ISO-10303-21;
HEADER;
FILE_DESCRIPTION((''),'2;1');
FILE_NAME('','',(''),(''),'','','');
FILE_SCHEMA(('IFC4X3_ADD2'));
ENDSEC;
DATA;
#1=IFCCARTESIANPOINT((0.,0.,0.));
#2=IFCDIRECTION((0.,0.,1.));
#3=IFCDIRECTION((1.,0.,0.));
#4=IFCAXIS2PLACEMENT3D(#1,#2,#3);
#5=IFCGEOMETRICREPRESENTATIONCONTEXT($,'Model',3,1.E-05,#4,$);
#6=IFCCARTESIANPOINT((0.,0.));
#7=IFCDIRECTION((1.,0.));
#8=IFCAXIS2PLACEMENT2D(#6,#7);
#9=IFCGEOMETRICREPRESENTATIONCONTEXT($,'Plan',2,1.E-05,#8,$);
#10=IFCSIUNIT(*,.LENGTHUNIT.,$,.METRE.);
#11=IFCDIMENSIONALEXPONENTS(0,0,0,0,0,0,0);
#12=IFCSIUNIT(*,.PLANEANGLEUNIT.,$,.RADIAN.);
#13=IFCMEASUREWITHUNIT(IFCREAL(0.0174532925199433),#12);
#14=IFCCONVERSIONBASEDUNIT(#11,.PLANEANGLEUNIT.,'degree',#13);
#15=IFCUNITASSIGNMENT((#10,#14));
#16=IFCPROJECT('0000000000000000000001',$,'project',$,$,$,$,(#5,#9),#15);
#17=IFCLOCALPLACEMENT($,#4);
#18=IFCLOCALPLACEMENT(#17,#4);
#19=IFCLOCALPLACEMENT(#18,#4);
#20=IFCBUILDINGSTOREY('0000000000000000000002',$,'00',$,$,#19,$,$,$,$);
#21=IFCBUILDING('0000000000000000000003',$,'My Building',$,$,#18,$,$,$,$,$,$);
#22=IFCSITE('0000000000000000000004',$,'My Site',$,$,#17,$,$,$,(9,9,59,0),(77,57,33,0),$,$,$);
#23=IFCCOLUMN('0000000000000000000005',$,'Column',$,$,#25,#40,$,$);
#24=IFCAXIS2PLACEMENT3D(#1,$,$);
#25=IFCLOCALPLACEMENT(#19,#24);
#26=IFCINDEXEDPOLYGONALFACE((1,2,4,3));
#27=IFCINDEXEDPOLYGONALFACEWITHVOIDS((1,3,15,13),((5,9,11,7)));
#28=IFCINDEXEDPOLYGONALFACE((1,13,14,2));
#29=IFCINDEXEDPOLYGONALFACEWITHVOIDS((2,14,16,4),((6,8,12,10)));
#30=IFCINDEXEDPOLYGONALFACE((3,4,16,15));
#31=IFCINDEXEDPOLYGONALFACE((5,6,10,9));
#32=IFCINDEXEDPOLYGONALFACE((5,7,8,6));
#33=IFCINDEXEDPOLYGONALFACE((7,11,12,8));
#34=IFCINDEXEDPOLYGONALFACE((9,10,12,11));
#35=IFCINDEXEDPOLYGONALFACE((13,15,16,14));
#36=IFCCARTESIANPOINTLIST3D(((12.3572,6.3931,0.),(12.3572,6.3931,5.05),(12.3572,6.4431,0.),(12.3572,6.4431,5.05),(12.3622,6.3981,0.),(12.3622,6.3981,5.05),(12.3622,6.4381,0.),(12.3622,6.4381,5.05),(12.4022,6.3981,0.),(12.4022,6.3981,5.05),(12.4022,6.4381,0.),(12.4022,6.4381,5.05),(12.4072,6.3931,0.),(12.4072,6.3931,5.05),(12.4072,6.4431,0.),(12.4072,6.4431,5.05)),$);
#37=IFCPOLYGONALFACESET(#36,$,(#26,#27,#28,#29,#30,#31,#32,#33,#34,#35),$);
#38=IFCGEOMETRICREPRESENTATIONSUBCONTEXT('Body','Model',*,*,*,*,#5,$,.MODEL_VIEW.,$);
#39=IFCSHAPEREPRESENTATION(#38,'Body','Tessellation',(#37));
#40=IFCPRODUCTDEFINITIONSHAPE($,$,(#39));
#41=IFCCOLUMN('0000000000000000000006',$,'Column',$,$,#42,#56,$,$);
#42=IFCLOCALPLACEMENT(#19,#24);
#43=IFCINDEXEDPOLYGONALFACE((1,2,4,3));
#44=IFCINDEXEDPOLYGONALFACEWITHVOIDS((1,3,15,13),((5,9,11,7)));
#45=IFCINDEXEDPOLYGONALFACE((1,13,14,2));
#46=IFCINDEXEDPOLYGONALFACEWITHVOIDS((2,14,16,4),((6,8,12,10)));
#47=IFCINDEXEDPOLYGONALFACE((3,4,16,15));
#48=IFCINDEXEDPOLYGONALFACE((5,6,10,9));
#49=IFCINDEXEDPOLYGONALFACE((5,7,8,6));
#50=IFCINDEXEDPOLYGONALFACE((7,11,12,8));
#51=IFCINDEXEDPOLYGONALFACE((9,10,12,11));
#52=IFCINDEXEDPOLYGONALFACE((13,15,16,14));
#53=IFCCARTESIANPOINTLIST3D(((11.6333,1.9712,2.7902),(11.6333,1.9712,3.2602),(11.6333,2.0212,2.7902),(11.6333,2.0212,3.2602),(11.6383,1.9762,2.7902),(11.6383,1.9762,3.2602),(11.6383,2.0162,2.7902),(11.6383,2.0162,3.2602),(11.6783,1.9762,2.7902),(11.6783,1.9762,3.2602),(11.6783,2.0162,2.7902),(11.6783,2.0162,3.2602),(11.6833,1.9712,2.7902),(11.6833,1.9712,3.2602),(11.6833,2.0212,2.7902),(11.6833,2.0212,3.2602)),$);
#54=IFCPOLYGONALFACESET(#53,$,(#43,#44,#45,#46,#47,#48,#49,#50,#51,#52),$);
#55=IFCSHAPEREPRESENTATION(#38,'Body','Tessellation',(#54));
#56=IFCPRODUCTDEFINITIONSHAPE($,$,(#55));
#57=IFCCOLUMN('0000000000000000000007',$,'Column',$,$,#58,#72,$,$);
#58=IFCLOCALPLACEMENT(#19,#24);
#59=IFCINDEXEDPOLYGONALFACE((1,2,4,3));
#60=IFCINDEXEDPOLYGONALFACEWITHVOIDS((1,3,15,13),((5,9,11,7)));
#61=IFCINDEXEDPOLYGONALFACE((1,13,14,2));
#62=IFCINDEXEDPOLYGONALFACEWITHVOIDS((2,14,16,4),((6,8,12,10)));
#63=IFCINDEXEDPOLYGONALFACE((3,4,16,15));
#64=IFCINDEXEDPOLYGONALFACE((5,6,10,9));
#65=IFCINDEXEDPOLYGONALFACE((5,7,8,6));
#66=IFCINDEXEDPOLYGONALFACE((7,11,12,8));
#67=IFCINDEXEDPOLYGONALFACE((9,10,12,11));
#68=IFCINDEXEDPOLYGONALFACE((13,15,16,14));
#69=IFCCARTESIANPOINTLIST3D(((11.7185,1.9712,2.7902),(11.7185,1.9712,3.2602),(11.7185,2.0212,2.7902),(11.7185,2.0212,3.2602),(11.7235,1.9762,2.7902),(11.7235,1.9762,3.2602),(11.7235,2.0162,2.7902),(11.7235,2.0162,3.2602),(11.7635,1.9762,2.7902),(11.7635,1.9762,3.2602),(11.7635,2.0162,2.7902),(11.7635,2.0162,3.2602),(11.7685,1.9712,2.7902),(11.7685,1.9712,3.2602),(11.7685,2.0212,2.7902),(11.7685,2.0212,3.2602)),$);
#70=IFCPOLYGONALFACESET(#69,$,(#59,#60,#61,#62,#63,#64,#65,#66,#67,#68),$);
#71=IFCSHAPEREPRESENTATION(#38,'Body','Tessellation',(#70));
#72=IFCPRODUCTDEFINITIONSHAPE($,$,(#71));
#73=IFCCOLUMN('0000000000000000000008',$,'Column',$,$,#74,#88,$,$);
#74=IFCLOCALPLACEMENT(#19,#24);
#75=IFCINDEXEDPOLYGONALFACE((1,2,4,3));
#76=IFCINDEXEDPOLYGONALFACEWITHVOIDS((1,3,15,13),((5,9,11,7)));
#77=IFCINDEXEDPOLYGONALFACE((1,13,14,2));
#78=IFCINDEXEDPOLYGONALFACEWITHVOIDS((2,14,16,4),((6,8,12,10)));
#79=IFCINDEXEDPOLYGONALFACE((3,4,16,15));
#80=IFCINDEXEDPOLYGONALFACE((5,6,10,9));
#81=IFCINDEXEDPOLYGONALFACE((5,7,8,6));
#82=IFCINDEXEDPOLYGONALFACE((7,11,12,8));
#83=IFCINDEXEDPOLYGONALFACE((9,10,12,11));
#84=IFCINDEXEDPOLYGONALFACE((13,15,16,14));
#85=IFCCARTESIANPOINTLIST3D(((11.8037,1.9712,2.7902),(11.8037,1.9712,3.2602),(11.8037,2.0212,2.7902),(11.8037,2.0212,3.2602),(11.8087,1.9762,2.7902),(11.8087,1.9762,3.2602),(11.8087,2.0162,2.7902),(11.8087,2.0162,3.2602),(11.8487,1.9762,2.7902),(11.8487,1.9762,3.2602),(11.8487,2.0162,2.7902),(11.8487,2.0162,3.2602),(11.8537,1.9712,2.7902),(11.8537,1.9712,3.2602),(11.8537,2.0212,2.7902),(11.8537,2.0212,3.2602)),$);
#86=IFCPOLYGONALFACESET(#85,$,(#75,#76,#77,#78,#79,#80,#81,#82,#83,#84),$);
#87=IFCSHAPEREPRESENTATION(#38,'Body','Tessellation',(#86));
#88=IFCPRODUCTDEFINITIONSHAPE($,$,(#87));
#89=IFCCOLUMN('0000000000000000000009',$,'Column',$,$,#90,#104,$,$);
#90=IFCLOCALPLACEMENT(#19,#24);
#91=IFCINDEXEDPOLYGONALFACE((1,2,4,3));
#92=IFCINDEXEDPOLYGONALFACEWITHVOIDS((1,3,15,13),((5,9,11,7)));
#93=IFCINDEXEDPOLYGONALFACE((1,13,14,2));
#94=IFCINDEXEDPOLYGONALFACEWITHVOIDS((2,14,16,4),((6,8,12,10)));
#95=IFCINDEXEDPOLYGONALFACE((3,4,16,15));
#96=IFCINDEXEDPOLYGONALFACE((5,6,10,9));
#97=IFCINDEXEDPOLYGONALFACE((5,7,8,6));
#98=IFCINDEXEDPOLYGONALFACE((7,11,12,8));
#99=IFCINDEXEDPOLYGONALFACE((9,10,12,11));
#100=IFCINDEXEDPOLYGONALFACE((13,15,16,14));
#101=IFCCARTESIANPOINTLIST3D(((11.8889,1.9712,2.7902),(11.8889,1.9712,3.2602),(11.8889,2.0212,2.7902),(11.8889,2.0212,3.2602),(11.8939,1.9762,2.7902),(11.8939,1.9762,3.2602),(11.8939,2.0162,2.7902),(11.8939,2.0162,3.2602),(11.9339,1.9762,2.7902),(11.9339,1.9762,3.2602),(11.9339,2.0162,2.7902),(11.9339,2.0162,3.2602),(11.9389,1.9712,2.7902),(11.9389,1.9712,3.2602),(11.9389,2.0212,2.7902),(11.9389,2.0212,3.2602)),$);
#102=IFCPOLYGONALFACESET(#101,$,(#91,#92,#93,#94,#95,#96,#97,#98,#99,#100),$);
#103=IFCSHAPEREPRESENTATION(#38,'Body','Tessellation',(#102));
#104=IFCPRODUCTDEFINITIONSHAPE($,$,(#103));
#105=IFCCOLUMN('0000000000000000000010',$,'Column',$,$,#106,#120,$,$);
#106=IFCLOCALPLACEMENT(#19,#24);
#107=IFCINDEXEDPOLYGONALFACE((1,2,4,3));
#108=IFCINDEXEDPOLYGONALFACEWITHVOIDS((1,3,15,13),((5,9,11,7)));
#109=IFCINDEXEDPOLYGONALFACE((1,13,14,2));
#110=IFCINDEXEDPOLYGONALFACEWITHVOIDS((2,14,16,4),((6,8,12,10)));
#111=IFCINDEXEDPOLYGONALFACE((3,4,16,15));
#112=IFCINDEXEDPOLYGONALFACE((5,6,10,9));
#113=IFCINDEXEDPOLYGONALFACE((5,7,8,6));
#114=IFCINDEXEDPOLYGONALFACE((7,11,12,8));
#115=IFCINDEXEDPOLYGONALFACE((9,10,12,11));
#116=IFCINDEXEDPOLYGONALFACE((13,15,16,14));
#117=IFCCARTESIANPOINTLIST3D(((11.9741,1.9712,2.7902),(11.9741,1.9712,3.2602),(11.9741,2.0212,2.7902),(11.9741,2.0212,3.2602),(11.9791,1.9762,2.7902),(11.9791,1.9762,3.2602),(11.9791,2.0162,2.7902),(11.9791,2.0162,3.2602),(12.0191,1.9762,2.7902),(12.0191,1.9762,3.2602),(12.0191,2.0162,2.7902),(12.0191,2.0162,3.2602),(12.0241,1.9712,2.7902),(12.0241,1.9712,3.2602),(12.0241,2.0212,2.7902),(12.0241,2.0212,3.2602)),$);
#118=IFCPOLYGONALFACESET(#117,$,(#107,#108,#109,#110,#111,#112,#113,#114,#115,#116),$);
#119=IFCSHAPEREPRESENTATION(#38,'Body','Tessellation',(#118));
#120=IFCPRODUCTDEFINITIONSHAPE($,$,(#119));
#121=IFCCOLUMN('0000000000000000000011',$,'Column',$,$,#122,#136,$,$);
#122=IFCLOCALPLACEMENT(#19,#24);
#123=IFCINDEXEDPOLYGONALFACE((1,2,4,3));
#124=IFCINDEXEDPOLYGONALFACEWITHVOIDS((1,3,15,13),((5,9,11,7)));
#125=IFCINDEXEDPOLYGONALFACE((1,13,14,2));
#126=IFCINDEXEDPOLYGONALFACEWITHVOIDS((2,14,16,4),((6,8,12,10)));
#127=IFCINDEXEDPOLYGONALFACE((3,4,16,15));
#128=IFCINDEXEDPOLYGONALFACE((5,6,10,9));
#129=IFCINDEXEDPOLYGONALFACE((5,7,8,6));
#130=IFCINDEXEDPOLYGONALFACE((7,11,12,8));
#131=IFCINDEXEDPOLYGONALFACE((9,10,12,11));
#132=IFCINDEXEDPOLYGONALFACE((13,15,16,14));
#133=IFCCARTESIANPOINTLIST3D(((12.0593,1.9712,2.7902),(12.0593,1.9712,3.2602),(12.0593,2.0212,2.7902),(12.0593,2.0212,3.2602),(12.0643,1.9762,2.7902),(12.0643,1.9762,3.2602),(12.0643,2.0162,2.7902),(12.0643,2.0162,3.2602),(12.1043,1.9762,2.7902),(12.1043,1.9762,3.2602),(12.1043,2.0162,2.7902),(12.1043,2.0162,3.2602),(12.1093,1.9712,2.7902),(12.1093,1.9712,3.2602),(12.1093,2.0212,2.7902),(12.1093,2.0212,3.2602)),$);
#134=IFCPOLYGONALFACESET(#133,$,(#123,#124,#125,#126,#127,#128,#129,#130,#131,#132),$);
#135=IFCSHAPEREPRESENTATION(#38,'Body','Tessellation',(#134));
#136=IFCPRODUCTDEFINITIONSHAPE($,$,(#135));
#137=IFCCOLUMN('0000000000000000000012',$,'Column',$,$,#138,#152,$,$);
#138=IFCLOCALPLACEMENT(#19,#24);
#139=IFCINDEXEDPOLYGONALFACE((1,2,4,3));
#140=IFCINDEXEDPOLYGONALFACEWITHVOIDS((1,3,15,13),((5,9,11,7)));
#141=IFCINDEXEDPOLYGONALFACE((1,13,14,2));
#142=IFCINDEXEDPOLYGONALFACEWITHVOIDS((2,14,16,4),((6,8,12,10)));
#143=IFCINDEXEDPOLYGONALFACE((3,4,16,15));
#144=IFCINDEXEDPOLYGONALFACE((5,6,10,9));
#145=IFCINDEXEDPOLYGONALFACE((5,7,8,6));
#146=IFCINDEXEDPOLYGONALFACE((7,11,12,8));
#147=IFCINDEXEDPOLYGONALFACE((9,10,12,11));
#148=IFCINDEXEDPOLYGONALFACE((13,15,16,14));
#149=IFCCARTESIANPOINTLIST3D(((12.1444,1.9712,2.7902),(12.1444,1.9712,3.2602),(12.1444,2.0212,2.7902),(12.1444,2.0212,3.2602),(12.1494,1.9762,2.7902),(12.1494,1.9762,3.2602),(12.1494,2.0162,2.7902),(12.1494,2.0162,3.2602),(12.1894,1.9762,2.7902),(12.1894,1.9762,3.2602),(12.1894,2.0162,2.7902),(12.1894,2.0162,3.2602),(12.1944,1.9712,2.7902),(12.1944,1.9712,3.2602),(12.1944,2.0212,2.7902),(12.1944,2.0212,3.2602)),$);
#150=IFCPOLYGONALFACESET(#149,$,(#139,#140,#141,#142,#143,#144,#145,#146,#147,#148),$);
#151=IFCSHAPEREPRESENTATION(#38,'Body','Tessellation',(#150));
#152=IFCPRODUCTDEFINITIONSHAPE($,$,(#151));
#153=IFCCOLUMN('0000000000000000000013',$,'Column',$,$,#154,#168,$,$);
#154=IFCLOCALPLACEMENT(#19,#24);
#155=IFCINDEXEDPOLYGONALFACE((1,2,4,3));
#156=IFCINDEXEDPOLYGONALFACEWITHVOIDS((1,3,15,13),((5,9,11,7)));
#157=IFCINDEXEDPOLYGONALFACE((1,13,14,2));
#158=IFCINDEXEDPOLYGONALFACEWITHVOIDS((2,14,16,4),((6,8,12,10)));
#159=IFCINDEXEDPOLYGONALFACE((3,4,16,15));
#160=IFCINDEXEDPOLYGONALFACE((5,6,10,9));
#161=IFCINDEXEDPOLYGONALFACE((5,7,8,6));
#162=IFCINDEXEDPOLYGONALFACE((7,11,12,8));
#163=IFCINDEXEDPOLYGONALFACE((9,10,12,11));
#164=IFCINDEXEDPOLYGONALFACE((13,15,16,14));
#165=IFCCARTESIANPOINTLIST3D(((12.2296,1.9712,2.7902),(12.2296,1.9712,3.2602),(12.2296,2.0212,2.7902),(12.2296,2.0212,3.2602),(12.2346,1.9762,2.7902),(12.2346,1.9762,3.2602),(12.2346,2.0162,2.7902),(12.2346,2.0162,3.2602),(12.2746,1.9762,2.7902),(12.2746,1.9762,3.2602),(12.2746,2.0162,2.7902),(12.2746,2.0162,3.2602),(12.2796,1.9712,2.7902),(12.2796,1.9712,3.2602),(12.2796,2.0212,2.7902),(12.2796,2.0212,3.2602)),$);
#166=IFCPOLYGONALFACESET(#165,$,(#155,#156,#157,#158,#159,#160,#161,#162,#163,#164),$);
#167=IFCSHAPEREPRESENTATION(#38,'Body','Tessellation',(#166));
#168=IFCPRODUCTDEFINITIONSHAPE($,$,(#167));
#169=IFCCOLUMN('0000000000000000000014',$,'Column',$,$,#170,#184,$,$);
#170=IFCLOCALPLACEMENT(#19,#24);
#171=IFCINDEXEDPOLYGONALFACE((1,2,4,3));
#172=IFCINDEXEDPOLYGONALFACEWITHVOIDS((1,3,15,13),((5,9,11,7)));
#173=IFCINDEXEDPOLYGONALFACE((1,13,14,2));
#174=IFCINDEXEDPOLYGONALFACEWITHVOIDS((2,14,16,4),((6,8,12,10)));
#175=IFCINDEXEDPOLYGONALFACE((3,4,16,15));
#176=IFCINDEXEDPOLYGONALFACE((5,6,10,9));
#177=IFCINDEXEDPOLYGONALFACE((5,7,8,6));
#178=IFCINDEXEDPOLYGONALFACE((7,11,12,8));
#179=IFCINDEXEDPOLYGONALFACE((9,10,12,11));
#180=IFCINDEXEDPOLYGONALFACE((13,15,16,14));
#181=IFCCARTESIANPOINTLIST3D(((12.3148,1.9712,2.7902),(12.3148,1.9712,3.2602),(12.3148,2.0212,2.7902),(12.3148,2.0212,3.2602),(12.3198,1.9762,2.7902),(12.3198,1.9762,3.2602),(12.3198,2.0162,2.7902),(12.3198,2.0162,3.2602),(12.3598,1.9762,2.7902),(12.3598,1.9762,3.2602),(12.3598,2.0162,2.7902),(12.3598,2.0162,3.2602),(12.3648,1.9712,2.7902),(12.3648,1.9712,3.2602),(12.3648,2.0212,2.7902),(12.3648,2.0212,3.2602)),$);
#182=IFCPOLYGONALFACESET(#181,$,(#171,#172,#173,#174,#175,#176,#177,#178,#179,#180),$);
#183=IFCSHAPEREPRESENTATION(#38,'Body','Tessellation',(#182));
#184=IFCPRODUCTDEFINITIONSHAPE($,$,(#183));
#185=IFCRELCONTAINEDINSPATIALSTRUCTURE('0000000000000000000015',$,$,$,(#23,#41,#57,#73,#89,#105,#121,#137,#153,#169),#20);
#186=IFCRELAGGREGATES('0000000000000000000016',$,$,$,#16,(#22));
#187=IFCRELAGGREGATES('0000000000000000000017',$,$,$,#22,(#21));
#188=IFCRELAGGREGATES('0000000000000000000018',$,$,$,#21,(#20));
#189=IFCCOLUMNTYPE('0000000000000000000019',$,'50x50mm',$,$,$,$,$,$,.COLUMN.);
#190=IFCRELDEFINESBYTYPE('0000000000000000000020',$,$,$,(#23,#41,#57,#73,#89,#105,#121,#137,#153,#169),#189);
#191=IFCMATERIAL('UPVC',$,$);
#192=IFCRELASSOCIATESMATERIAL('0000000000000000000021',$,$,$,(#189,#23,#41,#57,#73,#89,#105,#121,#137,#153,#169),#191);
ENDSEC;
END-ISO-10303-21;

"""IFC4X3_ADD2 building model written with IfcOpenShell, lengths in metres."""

from ifc_helpers import new_model, entity, si_unit, converted_unit, frame, origin_with_axes, origin_2d_with_axis, place, context, subcontext, project, spatial, hollow_rectangle, extrude, material, material_profile, profile_set, profile_usage, type_object, element, save


model = new_model("IFC4X3_ADD2")

# Units and contexts
model_context = context("Model", 3, precision=1e-05, world=origin_with_axes())
plan_context = context("Plan", 2, precision=1e-05, world=origin_2d_with_axis())
body_context = subcontext(model_context, "Body", "Model", "MODEL_VIEW")
ifc_project = project(units=[si_unit("LENGTHUNIT", "METRE"), converted_unit("PLANEANGLEUNIT", "degree", entity("IfcReal", 0.0174532925199433), si_unit("PLANEANGLEUNIT", "RADIAN"), dimensions=[0, 0, 0, 0, 0, 0, 0])], contexts=[model_context, plan_context])

# Site, building, storey
site_placement = place(None, origin_with_axes())
site = spatial("IfcSite", under=ifc_project, at=site_placement, Name="My Site", RefLatitude=(9, 9, 59, 0), RefLongitude=(77, 57, 33, 0))
building_placement = place(site_placement, origin_with_axes())
building = spatial("IfcBuilding", under=site, at=building_placement, Name="My Building")
storey_placement = place(building_placement, origin_with_axes())
storey = spatial("IfcBuildingStorey", under=building, at=storey_placement, Name="00")

# Columns
ifc_material_1 = material(Name="UPVC")
ifc_material_profile_1 = material_profile(ifc_material_1, hollow_rectangle(XDim=0.05, YDim=0.05, WallThickness=0.005))
ifc_profile_set_1 = profile_set([ifc_material_profile_1])
ifc_profile_usage_1 = profile_usage(ifc_profile_set_1, cardinal=5)
column_type_1 = type_object("IfcColumnType", Name="50x50mm", PredefinedType="COLUMN", material=ifc_profile_set_1)
column_1_placement = place(storey_placement, frame((12.3822, 6.4181, 0.0), z_axis=(0.0, 0.0, 1.0), x_axis=(1.0, 0.0, 0.0)))
element("IfcColumn", 1, at=column_1_placement, inside=storey, type_object=column_type_1, material=ifc_profile_usage_1, Name="Column", context=body_context, shape_type="SweptSolid", body=[
    extrude(hollow_rectangle(XDim=0.05, YDim=0.05, WallThickness=0.005), origin_with_axes(), (0.0, 0.0, 1.0), 5.05),
])
ifc_profile_usage_2 = profile_usage(ifc_profile_set_1, cardinal=5)
column_2_placement = place(storey_placement, frame((11.6583, 1.9962, 2.7902), z_axis=(0.0, 0.0, 1.0), x_axis=(1.0, 0.0, 0.0)))
element("IfcColumn", 2, at=column_2_placement, inside=storey, type_object=column_type_1, material=ifc_profile_usage_2, Name="Column", context=body_context, shape_type="SweptSolid", body=[
    extrude(hollow_rectangle(XDim=0.05, YDim=0.05, WallThickness=0.005), origin_with_axes(), (0.0, 0.0, 1.0), 0.47),
])
ifc_profile_usage_3 = profile_usage(ifc_profile_set_1, cardinal=5)
column_3_placement = place(storey_placement, frame((11.7435, 1.9962, 2.7902), z_axis=(0.0, 0.0, 1.0), x_axis=(1.0, 0.0, 0.0)))
element("IfcColumn", 3, at=column_3_placement, inside=storey, type_object=column_type_1, material=ifc_profile_usage_3, Name="Column", context=body_context, shape_type="SweptSolid", body=[
    extrude(hollow_rectangle(XDim=0.05, YDim=0.05, WallThickness=0.005), origin_with_axes(), (0.0, 0.0, 1.0), 0.47),
])
ifc_profile_usage_4 = profile_usage(ifc_profile_set_1, cardinal=5)
column_4_placement = place(storey_placement, frame((11.8287, 1.9962, 2.7902), z_axis=(0.0, 0.0, 1.0), x_axis=(1.0, 0.0, 0.0)))
element("IfcColumn", 4, at=column_4_placement, inside=storey, type_object=column_type_1, material=ifc_profile_usage_4, Name="Column", context=body_context, shape_type="SweptSolid", body=[
    extrude(hollow_rectangle(XDim=0.05, YDim=0.05, WallThickness=0.005), origin_with_axes(), (0.0, 0.0, 1.0), 0.47),
])
ifc_profile_usage_5 = profile_usage(ifc_profile_set_1, cardinal=5)
column_5_placement = place(storey_placement, frame((11.9139, 1.9962, 2.7902), z_axis=(0.0, 0.0, 1.0), x_axis=(1.0, 0.0, 0.0)))
element("IfcColumn", 5, at=column_5_placement, inside=storey, type_object=column_type_1, material=ifc_profile_usage_5, Name="Column", context=body_context, shape_type="SweptSolid", body=[
    extrude(hollow_rectangle(XDim=0.05, YDim=0.05, WallThickness=0.005), origin_with_axes(), (0.0, 0.0, 1.0), 0.47),
])
ifc_profile_usage_6 = profile_usage(ifc_profile_set_1, cardinal=5)
column_6_placement = place(storey_placement, frame((11.9991, 1.9962, 2.7902), z_axis=(0.0, 0.0, 1.0), x_axis=(1.0, 0.0, 0.0)))
element("IfcColumn", 6, at=column_6_placement, inside=storey, type_object=column_type_1, material=ifc_profile_usage_6, Name="Column", context=body_context, shape_type="SweptSolid", body=[
    extrude(hollow_rectangle(XDim=0.05, YDim=0.05, WallThickness=0.005), origin_with_axes(), (0.0, 0.0, 1.0), 0.47),
])
ifc_profile_usage_7 = profile_usage(ifc_profile_set_1, cardinal=5)
column_7_placement = place(storey_placement, frame((12.0843, 1.9962, 2.7902), z_axis=(0.0, 0.0, 1.0), x_axis=(1.0, 0.0, 0.0)))
element("IfcColumn", 7, at=column_7_placement, inside=storey, type_object=column_type_1, material=ifc_profile_usage_7, Name="Column", context=body_context, shape_type="SweptSolid", body=[
    extrude(hollow_rectangle(XDim=0.05, YDim=0.05, WallThickness=0.005), origin_with_axes(), (0.0, 0.0, 1.0), 0.47),
])
ifc_profile_usage_8 = profile_usage(ifc_profile_set_1, cardinal=5)
column_8_placement = place(storey_placement, frame((12.1694, 1.9962, 2.7902), z_axis=(0.0, 0.0, 1.0), x_axis=(1.0, 0.0, 0.0)))
element("IfcColumn", 8, at=column_8_placement, inside=storey, type_object=column_type_1, material=ifc_profile_usage_8, Name="Column", context=body_context, shape_type="SweptSolid", body=[
    extrude(hollow_rectangle(XDim=0.05, YDim=0.05, WallThickness=0.005), origin_with_axes(), (0.0, 0.0, 1.0), 0.47),
])
ifc_profile_usage_9 = profile_usage(ifc_profile_set_1, cardinal=5)
column_9_placement = place(storey_placement, frame((12.2546, 1.9962, 2.7902), z_axis=(0.0, 0.0, 1.0), x_axis=(1.0, 0.0, 0.0)))
element("IfcColumn", 9, at=column_9_placement, inside=storey, type_object=column_type_1, material=ifc_profile_usage_9, Name="Column", context=body_context, shape_type="SweptSolid", body=[
    extrude(hollow_rectangle(XDim=0.05, YDim=0.05, WallThickness=0.005), origin_with_axes(), (0.0, 0.0, 1.0), 0.47),
])
ifc_profile_usage_10 = profile_usage(ifc_profile_set_1, cardinal=5)
column_10_placement = place(storey_placement, frame((12.3398, 1.9962, 2.7902), z_axis=(0.0, 0.0, 1.0), x_axis=(1.0, 0.0, 0.0)))
element("IfcColumn", 10, at=column_10_placement, inside=storey, type_object=column_type_1, material=ifc_profile_usage_10, Name="Column", context=body_context, shape_type="SweptSolid", body=[
    extrude(hollow_rectangle(XDim=0.05, YDim=0.05, WallThickness=0.005), origin_with_axes(), (0.0, 0.0, 1.0), 0.47),
])

save(model, "model.ifc")
